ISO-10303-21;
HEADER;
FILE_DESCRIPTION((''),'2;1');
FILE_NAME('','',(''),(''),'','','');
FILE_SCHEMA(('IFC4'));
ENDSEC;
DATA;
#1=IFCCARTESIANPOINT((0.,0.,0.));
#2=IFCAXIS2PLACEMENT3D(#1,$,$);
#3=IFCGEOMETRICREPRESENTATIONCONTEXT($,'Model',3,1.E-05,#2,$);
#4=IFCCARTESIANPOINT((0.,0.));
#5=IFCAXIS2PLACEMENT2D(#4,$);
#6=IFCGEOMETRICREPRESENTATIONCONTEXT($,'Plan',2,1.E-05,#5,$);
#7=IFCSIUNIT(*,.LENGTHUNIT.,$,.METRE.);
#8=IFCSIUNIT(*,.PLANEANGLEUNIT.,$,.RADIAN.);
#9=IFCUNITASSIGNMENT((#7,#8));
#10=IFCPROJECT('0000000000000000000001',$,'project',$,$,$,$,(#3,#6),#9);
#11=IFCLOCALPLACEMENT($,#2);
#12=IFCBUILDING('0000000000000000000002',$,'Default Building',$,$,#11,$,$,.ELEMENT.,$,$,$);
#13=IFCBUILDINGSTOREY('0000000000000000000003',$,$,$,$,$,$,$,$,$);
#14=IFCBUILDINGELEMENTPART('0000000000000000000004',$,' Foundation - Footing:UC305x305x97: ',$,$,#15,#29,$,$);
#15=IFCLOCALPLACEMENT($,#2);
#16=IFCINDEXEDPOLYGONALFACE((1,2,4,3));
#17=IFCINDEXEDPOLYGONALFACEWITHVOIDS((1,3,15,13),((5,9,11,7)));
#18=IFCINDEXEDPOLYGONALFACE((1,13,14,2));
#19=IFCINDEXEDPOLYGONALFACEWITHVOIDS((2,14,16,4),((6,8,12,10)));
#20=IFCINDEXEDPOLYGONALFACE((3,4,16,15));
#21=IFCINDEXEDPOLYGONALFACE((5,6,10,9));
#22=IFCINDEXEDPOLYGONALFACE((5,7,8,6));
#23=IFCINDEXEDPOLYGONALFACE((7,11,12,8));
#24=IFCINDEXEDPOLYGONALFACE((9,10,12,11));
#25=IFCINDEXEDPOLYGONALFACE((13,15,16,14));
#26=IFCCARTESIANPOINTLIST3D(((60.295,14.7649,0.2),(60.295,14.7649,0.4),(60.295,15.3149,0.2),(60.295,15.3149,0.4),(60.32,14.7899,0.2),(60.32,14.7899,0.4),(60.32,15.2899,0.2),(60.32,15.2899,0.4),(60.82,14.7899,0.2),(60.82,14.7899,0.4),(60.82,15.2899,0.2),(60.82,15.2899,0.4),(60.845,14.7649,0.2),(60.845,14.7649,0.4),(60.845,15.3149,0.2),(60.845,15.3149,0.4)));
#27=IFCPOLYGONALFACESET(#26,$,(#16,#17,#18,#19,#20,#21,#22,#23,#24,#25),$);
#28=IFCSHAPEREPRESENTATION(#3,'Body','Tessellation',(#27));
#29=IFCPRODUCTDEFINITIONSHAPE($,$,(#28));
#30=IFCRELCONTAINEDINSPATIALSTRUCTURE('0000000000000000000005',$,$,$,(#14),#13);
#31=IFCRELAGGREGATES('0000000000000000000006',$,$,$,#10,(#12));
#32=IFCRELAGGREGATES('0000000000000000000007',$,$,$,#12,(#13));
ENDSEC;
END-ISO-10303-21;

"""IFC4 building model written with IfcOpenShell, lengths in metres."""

from ifc_helpers import new_model, si_unit, origin, origin_2d, place, context, project, spatial, polyline, outline, extrude, element, save


model = new_model("IFC4")

# Units and contexts
model_context = context("Model", 3, precision=1e-05, world=origin())
plan_context = context("Plan", 2, precision=1e-05, world=origin_2d())
ifc_project = project(units=[si_unit("LENGTHUNIT", "METRE"), si_unit("PLANEANGLEUNIT", "RADIAN")], contexts=[model_context, plan_context])

# Building, storey
building_placement = place(None, origin())
building = spatial("IfcBuilding", under=ifc_project, at=building_placement, Name="Default Building", CompositionType="ELEMENT")
storey = spatial("IfcBuildingStorey", under=building)

# Building element part, opening
building_element_part_1 = element("IfcBuildingElementPart", 1, inside=storey, Name=" Foundation - Footing:UC305x305x97: ", context=model_context, shape_type="SweptSolid", body=[
    extrude(outline(polyline([(60.845, 15.3149, 0.2), (60.295, 15.3149, 0.2), (60.295, 14.7649, 0.2), (60.845, 14.7649, 0.2), (60.845, 15.3149, 0.2)])), None, (0.0, 0.0, 1.0), 0.2),
])
element("IfcOpeningElement", 2, inside=storey, cuts=building_element_part_1, context=model_context, shape_type="SweptSolid", body=[
    extrude(outline(polyline([(60.82, 15.2899, 0.2), (60.32, 15.2899, 0.2), (60.32, 14.7899, 0.2), (60.82, 14.7899, 0.2), (60.82, 15.2899, 0.2)])), None, (0.0, 0.0, 1.0), 0.2),
])

save(model, "model.ifc")
